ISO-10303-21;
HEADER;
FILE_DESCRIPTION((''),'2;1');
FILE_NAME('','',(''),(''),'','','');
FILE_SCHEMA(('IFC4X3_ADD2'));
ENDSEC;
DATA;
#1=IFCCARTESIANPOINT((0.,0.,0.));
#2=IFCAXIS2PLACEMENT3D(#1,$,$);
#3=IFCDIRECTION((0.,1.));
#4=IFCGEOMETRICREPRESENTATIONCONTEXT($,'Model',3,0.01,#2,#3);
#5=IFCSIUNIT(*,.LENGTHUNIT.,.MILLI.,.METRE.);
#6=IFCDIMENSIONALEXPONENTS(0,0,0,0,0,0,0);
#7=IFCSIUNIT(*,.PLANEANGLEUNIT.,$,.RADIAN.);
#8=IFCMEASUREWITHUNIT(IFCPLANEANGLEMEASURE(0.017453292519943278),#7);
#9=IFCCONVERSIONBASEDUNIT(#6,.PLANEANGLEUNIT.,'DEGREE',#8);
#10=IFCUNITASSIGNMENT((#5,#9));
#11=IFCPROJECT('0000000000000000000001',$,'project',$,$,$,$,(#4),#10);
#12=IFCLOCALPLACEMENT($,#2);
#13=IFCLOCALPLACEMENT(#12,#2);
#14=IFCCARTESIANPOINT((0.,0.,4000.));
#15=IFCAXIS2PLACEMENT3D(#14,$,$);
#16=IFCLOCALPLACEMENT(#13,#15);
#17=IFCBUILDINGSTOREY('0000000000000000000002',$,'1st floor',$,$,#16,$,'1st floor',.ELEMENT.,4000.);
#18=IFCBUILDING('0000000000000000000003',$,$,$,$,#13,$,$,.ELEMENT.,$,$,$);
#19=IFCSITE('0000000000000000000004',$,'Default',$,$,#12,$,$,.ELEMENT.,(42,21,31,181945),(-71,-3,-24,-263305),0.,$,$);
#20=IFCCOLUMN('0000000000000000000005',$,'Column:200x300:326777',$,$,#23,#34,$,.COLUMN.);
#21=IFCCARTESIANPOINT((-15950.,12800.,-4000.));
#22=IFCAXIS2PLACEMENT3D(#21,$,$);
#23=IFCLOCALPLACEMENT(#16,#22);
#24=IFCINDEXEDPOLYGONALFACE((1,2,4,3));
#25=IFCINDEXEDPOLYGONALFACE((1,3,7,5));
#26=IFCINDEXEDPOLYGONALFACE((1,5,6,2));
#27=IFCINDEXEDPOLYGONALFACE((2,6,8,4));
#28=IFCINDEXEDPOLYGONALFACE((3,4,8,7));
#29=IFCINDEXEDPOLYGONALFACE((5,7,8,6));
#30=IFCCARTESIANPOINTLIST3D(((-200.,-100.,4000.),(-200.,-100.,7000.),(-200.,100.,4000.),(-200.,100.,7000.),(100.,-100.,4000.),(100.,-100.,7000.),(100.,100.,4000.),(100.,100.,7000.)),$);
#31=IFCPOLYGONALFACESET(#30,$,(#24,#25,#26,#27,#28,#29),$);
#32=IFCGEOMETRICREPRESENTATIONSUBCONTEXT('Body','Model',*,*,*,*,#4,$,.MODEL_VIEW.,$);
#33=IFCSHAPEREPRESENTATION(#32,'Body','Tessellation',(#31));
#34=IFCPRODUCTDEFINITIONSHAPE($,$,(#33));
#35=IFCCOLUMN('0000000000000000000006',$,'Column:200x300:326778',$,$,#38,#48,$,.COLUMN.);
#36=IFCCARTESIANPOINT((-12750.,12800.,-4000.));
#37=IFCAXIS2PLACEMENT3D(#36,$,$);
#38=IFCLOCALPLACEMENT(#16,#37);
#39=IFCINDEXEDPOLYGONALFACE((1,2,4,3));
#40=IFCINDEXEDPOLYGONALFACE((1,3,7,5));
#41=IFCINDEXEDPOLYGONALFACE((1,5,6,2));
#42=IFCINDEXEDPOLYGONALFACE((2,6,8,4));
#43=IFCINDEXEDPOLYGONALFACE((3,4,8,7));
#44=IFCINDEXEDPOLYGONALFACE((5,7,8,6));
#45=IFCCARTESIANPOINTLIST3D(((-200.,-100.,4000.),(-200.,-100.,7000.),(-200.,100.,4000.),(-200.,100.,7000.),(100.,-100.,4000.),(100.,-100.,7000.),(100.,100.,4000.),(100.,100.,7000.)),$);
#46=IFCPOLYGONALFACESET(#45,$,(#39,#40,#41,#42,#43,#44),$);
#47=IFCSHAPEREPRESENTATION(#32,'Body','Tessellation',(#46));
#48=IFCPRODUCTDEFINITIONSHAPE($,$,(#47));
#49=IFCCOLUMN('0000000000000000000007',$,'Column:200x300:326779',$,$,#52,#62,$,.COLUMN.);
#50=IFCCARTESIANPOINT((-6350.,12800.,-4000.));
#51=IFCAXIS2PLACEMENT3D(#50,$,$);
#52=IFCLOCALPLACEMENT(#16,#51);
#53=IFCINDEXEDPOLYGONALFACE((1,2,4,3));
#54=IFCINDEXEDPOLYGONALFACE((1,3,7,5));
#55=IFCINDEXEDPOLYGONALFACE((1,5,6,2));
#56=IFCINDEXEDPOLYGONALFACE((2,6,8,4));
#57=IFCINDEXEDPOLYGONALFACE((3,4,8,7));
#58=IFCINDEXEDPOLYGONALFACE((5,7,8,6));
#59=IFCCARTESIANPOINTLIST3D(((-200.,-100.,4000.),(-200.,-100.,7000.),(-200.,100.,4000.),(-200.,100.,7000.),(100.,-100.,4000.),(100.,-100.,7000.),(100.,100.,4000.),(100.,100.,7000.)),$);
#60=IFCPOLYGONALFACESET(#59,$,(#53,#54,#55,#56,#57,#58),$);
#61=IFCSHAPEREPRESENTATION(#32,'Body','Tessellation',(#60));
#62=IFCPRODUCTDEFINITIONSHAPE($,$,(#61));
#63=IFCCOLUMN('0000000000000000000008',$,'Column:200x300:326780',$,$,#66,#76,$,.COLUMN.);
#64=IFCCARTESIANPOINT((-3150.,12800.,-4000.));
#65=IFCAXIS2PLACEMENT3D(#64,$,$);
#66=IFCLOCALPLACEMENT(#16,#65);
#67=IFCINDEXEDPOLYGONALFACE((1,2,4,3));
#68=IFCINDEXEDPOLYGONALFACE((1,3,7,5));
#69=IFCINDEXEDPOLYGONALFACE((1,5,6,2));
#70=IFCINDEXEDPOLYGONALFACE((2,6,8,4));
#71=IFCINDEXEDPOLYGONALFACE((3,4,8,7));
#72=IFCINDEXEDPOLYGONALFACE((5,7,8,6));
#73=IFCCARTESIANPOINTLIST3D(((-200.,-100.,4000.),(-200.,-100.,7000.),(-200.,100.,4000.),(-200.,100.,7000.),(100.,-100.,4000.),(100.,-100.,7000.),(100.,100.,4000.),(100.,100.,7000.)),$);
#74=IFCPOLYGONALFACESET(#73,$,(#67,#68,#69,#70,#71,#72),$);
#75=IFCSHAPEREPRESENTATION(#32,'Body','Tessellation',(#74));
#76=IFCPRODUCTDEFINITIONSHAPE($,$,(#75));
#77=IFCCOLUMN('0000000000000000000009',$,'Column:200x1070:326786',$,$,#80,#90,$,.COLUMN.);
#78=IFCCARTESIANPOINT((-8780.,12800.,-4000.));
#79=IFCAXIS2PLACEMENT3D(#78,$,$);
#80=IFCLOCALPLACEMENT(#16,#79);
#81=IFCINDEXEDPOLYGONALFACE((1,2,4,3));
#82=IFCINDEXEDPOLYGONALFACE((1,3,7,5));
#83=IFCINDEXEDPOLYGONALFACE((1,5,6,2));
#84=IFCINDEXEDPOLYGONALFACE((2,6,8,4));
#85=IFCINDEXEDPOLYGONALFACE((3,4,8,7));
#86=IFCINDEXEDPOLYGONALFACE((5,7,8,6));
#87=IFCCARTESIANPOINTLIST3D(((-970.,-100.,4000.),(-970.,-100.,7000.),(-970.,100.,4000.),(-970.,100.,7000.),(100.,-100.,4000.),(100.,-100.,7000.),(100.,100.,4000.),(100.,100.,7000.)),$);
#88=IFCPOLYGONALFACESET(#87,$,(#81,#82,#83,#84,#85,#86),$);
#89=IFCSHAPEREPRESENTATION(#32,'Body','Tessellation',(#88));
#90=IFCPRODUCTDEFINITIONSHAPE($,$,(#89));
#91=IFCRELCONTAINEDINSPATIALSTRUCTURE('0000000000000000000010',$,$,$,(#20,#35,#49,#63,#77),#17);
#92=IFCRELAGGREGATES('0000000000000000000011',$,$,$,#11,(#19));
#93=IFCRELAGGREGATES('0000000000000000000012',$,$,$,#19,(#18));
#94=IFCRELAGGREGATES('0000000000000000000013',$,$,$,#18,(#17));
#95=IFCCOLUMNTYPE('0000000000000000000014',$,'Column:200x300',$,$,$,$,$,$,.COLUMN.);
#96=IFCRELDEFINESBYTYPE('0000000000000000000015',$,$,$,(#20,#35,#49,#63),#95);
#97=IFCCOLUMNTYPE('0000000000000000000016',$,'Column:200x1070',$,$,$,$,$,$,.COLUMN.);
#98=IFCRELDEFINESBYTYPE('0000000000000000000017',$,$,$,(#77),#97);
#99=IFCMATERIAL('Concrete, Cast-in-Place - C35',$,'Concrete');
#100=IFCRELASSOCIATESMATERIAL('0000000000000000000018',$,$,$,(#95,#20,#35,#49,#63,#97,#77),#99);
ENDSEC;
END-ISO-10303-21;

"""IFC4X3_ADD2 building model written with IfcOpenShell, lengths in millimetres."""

from ifc_helpers import new_model, entity, si_unit, converted_unit, direction, frame, origin, origin_2d_with_axis, place, context, subcontext, project, spatial, rectangle, extrude, source, transform, mapped, material, material_profile, profile_set, profile_usage, type_object, type_shapes, element, save


model = new_model("IFC4X3_ADD2")

# Units and contexts
model_context = context("Model", 3, precision=0.01, world=origin(), true_north=direction((0.0, 1.0)))
body_context = subcontext(model_context, "Body", "Model", "MODEL_VIEW")
ifc_project = project(units=[si_unit("LENGTHUNIT", "METRE", prefix="MILLI"), converted_unit("PLANEANGLEUNIT", "DEGREE", entity("IfcPlaneAngleMeasure", 0.017453292519943278), si_unit("PLANEANGLEUNIT", "RADIAN"), dimensions=[0, 0, 0, 0, 0, 0, 0])], contexts=[model_context])

# Site, building, storey
site_placement = place(None, origin())
site = spatial("IfcSite", under=ifc_project, at=site_placement, Name="Default", CompositionType="ELEMENT", RefLatitude=(42, 21, 31, 181945), RefLongitude=(-71, -3, -24, -263305), RefElevation=0.0)
building_placement = place(site_placement, origin())
building = spatial("IfcBuilding", under=site, at=building_placement, CompositionType="ELEMENT")
storey_placement = place(building_placement, frame((0.0, 0.0, 4000.0)))
storey = spatial("IfcBuildingStorey", under=building, at=storey_placement, Name="1st floor", LongName="1st floor", CompositionType="ELEMENT", Elevation=4000.0)

# Columns
ifc_material_1 = material(Name="Concrete, Cast-in-Place - C35", Category="Concrete")
ifc_material_profile_1 = material_profile(ifc_material_1, rectangle(XDim=300.0, YDim=200.0, at=origin_2d_with_axis()), Name="200x300")
ifc_profile_set_1 = profile_set([ifc_material_profile_1], Name="200x300")
ifc_profile_usage_1 = profile_usage(ifc_profile_set_1)
column_type_1 = type_object("IfcColumnType", Name="Column:200x300", PredefinedType="COLUMN", material=ifc_profile_set_1)
shared_shape_1 = source(origin(), body_context, "Body", "SweptSolid", [
    extrude(rectangle(XDim=300.0, YDim=200.0, at=origin_2d_with_axis()), frame((-50.0, 0.0, 4000.0), z_axis=(0.0, 0.0, 1.0), x_axis=(-1.0, 0.0, 0.0)), (0.0, 0.0, 1.0), 3000.0),
])
type_shapes(column_type_1, [shared_shape_1])
for number, where, name in (
    (1, (-15950.0, 12800.0, -4000.0), "Column:200x300:326777"),
    (2, (-12750.0, 12800.0, -4000.0), "Column:200x300:326778"),
    (3, (-6350.0, 12800.0, -4000.0), "Column:200x300:326779"),
    (4, (-3150.0, 12800.0, -4000.0), "Column:200x300:326780"),
):
    element("IfcColumn", number, at=place(storey_placement, frame(where)), inside=storey, type_object=column_type_1, material=ifc_profile_usage_1, Name=name, PredefinedType="COLUMN", context=body_context, shape_type="MappedRepresentation", body=[
        mapped(shared_shape_1, transform((0.0, 0.0, 0.0), scale=1.0)),
    ])
ifc_material_profile_2 = material_profile(ifc_material_1, rectangle(XDim=1070.0, YDim=200.0, at=origin_2d_with_axis()), Name="200x1070")
ifc_profile_set_2 = profile_set([ifc_material_profile_2], Name="200x1070")
ifc_profile_usage_2 = profile_usage(ifc_profile_set_2)
column_type_2 = type_object("IfcColumnType", Name="Column:200x1070", PredefinedType="COLUMN", material=ifc_profile_set_2)
shared_shape_2 = source(origin(), body_context, "Body", "SweptSolid", [
    extrude(rectangle(XDim=1070.0, YDim=200.0, at=origin_2d_with_axis()), frame((-435.0, 0.0, 4000.0), z_axis=(0.0, 0.0, 1.0), x_axis=(-1.0, 0.0, 0.0)), (0.0, 0.0, 1.0), 3000.0),
])
type_shapes(column_type_2, [shared_shape_2])
column_placement = place(storey_placement, frame((-8780.0, 12800.0, -4000.0)))
element("IfcColumn", 5, at=column_placement, inside=storey, type_object=column_type_2, material=ifc_profile_usage_2, Name="Column:200x1070:326786", PredefinedType="COLUMN", context=body_context, shape_type="MappedRepresentation", body=[
    mapped(shared_shape_2, transform((0.0, 0.0, 0.0), scale=1.0)),
])

save(model, "model.ifc")
